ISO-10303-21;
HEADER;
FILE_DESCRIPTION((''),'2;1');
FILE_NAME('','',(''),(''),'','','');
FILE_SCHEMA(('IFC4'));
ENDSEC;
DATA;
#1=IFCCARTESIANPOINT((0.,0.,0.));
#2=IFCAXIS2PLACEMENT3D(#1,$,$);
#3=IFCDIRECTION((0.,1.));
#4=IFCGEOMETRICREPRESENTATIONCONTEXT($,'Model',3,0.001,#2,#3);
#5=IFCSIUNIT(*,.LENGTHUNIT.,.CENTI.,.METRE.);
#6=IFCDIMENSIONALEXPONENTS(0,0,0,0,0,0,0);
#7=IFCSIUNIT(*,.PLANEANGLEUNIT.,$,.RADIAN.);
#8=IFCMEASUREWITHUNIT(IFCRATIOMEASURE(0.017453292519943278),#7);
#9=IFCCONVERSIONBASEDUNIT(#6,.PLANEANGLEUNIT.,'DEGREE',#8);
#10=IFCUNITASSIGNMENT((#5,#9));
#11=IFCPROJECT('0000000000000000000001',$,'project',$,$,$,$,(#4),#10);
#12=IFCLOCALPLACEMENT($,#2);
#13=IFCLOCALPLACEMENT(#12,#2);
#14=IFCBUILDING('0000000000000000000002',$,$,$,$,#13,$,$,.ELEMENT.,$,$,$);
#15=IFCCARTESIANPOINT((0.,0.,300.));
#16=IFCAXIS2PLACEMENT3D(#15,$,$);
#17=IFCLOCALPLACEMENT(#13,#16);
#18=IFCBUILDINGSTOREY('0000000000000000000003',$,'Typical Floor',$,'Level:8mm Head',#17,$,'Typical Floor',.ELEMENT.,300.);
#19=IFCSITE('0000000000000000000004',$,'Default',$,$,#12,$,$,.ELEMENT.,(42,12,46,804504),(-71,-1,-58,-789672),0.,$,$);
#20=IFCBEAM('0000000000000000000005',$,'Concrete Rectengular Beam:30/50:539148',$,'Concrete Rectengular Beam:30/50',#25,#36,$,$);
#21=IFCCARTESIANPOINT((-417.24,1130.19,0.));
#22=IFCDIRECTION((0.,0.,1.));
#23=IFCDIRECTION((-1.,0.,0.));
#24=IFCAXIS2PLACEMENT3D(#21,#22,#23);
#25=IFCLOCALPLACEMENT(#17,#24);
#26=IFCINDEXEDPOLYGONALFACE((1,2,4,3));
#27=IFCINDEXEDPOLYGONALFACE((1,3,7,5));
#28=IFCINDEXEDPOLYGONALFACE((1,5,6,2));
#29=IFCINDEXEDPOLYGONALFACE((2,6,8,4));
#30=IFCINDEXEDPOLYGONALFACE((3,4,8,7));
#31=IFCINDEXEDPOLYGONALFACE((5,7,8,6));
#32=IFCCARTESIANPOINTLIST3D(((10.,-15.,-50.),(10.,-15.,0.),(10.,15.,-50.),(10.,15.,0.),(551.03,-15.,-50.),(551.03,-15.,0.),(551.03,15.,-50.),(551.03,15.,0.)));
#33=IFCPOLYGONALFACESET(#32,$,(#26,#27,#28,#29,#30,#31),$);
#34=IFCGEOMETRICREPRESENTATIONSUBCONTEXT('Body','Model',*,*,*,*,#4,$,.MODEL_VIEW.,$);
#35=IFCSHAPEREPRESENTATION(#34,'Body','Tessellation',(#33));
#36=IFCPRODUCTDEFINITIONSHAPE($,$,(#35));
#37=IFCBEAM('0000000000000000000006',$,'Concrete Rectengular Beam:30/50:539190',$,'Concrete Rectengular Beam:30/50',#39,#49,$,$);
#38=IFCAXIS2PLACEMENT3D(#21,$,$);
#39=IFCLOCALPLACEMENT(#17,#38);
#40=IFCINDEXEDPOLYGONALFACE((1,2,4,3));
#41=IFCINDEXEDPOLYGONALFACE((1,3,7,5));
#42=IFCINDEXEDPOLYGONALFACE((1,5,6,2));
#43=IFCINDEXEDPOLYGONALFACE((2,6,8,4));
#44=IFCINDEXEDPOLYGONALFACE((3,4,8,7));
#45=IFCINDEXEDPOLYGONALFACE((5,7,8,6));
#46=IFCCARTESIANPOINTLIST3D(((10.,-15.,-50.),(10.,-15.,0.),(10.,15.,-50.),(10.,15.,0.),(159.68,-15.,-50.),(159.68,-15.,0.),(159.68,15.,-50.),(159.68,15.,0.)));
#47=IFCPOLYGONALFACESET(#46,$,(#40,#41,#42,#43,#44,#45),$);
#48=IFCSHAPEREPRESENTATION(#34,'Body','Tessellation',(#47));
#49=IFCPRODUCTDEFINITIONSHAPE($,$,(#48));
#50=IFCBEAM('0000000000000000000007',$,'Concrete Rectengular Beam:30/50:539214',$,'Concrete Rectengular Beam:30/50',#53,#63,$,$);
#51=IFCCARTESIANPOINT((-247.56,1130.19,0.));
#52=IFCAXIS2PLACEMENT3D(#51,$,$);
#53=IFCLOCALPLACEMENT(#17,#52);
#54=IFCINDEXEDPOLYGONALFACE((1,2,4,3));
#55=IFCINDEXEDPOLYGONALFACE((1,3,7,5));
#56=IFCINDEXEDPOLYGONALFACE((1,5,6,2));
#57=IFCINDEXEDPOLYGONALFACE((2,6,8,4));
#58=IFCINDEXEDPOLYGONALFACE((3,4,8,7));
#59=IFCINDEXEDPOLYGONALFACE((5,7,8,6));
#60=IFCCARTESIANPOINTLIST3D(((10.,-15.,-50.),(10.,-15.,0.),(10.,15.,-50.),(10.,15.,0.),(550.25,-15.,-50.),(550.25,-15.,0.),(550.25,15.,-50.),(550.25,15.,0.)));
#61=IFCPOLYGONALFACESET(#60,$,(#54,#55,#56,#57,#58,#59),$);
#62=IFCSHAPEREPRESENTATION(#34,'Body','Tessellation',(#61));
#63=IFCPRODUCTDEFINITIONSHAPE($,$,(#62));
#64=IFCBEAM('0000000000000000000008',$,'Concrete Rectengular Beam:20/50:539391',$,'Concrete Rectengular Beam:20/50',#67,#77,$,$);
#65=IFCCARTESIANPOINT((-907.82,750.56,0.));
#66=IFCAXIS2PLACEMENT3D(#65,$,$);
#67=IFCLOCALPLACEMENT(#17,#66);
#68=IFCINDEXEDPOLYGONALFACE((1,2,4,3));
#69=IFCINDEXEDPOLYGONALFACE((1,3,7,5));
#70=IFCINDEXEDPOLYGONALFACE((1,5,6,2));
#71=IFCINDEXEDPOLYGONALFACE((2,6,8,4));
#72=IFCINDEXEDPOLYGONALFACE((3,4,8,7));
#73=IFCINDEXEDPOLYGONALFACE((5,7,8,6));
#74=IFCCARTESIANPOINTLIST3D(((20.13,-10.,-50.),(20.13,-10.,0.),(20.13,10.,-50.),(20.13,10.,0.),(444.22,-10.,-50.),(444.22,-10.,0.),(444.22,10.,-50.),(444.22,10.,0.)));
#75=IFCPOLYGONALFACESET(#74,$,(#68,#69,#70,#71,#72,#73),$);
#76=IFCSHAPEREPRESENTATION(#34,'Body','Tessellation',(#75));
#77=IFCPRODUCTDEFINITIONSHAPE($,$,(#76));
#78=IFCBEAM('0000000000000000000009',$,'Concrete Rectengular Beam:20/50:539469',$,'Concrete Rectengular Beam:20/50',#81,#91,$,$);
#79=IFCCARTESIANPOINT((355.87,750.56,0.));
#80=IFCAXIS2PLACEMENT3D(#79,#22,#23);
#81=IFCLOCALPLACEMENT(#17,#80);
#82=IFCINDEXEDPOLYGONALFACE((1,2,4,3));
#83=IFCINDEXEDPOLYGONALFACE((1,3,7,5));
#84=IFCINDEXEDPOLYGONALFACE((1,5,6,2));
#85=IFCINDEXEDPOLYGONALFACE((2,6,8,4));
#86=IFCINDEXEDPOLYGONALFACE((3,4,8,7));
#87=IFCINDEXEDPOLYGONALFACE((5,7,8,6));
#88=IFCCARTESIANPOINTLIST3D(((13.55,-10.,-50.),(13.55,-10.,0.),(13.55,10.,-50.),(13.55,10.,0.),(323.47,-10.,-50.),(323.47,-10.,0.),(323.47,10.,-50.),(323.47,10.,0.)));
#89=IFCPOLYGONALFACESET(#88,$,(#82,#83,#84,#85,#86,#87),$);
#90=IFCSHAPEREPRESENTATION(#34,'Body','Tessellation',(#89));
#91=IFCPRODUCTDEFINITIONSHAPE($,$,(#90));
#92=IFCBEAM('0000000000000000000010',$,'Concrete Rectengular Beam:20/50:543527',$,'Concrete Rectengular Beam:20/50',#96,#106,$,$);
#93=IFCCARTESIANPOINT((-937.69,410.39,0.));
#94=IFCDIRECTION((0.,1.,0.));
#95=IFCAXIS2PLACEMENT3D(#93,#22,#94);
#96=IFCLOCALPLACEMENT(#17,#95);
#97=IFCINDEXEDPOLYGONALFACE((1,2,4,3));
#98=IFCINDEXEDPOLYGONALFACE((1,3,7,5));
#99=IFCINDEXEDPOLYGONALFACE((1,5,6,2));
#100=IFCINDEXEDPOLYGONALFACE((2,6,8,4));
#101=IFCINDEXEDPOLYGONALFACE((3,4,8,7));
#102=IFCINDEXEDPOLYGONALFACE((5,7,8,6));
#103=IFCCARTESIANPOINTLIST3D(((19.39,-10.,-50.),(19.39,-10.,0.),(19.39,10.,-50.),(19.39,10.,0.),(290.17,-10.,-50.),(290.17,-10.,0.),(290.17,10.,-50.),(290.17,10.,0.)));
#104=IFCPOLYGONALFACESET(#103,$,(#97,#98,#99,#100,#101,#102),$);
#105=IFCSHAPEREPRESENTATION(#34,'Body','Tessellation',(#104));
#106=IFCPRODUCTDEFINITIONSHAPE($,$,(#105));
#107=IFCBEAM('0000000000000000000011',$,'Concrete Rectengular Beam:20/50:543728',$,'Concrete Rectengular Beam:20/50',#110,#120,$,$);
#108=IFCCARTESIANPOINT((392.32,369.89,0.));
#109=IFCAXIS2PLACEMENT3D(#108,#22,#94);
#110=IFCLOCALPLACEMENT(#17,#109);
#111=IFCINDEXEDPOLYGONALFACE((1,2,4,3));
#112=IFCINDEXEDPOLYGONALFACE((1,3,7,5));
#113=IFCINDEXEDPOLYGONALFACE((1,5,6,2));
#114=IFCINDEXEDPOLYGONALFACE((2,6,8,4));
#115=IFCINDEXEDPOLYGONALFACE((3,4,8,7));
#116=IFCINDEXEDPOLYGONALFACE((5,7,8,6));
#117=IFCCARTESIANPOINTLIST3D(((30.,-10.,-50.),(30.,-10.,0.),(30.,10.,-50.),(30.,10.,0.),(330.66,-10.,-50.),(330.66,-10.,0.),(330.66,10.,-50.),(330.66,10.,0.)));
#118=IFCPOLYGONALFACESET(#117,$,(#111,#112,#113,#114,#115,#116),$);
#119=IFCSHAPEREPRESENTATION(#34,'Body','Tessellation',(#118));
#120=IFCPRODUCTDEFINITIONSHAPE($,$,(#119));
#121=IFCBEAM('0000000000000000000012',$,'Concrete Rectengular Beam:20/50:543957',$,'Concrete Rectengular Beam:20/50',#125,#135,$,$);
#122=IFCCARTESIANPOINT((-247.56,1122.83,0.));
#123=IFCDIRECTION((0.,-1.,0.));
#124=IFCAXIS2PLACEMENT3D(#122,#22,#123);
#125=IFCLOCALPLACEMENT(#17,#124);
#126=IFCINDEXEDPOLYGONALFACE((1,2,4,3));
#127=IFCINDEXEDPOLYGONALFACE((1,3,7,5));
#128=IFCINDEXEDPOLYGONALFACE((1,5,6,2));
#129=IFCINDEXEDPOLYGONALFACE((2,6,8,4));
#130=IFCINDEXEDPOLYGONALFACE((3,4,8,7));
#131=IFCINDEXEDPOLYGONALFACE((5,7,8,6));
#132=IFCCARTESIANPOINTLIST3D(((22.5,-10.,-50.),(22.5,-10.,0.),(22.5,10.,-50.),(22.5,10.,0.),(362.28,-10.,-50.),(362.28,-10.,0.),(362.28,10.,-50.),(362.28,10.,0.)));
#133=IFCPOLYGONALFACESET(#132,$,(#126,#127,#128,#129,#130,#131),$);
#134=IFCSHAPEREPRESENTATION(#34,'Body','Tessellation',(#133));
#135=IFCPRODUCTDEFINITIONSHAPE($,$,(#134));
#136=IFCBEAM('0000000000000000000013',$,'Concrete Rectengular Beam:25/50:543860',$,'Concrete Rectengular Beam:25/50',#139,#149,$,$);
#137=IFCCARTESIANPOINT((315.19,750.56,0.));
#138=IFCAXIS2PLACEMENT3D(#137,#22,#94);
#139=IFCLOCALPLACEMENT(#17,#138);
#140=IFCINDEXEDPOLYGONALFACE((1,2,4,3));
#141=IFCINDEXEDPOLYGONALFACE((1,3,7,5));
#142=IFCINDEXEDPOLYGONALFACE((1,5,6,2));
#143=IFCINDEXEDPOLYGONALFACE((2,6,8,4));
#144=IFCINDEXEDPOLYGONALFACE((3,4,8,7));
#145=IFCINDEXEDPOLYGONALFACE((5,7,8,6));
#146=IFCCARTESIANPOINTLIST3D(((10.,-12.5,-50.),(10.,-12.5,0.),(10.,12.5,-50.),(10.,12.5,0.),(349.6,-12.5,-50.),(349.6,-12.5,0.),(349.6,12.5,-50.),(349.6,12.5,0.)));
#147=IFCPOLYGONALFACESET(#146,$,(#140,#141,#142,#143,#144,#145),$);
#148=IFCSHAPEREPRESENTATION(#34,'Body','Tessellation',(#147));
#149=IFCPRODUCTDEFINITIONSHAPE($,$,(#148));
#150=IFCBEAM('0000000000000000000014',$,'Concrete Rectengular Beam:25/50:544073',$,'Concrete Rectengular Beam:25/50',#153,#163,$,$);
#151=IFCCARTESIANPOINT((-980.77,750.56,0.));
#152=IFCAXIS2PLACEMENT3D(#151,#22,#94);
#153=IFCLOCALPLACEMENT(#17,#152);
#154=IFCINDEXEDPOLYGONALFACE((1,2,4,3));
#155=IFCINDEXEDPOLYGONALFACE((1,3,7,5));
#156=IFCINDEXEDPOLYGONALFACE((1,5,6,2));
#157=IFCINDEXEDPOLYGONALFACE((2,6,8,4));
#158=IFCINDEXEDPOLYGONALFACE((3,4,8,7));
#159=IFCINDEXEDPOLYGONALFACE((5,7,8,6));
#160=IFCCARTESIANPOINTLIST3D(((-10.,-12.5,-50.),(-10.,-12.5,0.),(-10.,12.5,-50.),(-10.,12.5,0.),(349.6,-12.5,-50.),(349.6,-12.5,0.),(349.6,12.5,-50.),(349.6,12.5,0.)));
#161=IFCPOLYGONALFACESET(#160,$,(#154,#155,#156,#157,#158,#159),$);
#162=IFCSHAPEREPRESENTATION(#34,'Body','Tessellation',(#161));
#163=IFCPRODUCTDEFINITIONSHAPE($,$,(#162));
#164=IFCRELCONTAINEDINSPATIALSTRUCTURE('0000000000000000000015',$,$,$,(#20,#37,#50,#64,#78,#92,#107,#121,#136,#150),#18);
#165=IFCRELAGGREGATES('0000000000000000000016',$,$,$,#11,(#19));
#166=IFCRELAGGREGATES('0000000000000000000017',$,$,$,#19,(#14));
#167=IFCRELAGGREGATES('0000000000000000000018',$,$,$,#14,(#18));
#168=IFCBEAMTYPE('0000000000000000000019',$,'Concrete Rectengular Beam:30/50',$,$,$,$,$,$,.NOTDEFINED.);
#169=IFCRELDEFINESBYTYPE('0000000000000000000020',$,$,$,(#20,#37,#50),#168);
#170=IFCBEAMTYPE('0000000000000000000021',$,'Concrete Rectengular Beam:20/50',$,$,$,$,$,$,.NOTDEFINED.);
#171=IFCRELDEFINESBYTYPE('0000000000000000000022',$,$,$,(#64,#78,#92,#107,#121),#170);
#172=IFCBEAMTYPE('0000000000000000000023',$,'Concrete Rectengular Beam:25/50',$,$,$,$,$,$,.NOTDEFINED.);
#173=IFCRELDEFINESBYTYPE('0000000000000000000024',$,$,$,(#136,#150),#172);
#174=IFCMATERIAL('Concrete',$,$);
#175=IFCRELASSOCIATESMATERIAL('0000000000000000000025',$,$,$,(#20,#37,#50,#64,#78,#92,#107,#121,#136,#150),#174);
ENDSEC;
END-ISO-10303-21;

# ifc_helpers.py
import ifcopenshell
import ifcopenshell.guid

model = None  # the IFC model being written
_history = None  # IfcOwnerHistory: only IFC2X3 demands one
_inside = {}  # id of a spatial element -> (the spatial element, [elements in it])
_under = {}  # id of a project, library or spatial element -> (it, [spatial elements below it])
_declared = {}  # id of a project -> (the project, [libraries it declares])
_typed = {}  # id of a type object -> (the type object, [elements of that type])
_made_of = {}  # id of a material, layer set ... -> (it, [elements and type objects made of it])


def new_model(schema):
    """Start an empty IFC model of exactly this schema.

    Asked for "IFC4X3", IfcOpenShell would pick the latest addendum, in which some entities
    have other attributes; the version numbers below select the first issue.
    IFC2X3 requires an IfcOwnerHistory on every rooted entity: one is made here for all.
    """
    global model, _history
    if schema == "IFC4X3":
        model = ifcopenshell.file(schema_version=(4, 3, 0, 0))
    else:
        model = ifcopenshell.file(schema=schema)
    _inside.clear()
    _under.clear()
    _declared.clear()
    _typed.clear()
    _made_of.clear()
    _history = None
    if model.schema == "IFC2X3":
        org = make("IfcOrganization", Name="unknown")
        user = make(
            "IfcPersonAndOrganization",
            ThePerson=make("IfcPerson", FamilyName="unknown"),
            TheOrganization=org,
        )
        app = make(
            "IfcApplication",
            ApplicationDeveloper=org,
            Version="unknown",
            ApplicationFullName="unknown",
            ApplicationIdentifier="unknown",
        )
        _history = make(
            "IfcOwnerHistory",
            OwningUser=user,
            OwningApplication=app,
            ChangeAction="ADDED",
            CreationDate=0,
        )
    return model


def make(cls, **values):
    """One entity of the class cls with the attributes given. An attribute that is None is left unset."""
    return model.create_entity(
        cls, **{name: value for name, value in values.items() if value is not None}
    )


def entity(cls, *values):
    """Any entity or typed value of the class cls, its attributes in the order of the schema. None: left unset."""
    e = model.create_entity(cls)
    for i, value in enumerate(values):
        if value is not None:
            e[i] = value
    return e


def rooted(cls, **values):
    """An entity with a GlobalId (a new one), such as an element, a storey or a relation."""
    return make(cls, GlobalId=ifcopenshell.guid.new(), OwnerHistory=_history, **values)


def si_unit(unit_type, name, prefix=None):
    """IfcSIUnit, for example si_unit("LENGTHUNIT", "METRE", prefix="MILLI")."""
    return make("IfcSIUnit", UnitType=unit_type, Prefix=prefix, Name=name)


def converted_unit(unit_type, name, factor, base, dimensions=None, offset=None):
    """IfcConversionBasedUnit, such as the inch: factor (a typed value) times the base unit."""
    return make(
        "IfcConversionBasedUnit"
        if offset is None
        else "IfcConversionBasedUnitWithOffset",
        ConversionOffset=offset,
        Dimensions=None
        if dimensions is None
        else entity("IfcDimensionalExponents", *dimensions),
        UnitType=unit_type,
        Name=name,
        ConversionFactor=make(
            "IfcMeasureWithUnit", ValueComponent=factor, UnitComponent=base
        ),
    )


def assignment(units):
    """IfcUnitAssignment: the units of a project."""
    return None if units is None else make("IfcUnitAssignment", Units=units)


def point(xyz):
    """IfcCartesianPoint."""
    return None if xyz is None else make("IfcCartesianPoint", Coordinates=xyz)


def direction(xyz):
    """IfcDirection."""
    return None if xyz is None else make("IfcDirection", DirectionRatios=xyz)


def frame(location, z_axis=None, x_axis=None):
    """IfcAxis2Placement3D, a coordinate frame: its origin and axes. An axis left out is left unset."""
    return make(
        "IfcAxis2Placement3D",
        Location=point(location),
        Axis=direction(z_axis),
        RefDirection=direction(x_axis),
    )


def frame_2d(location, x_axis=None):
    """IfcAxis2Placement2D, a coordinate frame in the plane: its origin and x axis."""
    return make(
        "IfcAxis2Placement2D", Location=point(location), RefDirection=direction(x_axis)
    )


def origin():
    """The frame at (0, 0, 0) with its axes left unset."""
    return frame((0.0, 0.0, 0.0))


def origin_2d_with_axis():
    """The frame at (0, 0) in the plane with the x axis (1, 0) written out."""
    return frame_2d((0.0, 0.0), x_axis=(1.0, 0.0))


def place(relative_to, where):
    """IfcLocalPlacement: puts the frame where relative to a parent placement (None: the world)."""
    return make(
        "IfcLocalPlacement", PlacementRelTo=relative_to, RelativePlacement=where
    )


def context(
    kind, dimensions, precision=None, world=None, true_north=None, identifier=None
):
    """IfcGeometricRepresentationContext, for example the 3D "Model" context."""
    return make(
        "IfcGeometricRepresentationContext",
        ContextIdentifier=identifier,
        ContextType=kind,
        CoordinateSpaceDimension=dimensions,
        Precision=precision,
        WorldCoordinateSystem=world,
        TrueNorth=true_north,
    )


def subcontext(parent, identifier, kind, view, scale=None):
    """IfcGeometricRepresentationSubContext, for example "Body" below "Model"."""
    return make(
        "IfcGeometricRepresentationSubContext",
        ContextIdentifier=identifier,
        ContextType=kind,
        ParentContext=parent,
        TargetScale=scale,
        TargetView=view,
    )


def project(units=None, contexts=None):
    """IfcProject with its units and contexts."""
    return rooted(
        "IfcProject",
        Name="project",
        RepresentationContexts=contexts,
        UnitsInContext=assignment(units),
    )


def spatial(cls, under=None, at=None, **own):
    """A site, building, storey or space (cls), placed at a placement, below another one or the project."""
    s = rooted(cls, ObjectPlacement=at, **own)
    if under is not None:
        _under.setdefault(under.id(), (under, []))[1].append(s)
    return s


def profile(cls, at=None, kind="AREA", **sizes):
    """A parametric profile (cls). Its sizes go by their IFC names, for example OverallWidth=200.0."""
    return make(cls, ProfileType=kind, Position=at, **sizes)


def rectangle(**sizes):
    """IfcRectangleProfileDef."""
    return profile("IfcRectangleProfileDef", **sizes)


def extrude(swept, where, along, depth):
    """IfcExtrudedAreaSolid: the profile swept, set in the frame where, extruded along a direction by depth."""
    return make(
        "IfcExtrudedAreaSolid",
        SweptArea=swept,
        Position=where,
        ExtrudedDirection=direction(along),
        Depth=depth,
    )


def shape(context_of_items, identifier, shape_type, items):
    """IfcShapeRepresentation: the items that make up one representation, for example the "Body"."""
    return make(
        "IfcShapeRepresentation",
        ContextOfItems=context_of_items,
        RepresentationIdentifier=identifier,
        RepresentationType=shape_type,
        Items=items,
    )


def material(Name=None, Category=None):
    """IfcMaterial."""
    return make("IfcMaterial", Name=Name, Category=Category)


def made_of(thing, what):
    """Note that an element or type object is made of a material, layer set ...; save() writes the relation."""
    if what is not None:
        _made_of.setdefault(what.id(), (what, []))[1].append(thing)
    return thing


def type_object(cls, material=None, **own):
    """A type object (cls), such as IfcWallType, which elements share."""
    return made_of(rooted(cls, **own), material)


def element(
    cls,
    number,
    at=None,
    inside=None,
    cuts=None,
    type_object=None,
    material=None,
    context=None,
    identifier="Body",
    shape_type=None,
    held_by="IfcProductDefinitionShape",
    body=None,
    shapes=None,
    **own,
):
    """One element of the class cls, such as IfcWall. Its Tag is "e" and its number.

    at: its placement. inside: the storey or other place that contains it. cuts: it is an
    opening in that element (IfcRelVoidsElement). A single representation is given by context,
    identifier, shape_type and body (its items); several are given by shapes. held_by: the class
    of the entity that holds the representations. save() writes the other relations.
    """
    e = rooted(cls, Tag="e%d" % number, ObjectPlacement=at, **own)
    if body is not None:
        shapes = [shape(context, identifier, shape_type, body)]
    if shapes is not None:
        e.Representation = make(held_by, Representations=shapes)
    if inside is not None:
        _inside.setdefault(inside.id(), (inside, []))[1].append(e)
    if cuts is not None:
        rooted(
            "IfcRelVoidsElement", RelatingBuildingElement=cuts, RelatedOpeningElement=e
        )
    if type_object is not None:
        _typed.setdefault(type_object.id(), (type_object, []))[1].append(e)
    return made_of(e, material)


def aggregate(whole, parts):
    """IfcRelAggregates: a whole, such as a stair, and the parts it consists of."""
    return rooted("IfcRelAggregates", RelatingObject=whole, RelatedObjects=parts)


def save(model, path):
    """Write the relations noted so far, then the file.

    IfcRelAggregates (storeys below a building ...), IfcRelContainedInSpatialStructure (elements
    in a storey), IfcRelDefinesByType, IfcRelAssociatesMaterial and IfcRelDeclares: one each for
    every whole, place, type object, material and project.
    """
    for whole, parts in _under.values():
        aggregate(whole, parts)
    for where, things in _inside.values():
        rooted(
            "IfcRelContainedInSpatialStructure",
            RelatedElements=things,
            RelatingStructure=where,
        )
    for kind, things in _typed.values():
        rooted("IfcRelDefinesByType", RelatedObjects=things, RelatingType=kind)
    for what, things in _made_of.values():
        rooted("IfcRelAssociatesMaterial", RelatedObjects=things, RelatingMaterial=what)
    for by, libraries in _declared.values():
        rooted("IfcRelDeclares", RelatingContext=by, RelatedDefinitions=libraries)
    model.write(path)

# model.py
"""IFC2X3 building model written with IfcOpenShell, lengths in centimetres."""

from ifc_helpers import new_model, entity, si_unit, converted_unit, direction, frame, frame_2d, origin, origin_2d_with_axis, place, context, subcontext, project, spatial, rectangle, extrude, material, type_object, element, save


model = new_model("IFC2X3")

# Units and contexts
model_context = context("Model", 3, precision=0.001, world=origin(), true_north=direction((0.0, 1.0)))
body_context = subcontext(model_context, "Body", "Model", "MODEL_VIEW")
ifc_project = project(units=[si_unit("LENGTHUNIT", "METRE", prefix="CENTI"), converted_unit("PLANEANGLEUNIT", "DEGREE", entity("IfcRatioMeasure", 0.017453292519943278), si_unit("PLANEANGLEUNIT", "RADIAN"), dimensions=[0, 0, 0, 0, 0, 0, 0])], contexts=[model_context])

# Site, building, storey
site_placement = place(None, origin())
site = spatial("IfcSite", under=ifc_project, at=site_placement, Name="Default", CompositionType="ELEMENT", RefLatitude=(42, 12, 46, 804504), RefLongitude=(-71, -1, -58, -789672), RefElevation=0.0)
building_placement = place(site_placement, origin())
building = spatial("IfcBuilding", under=site, at=building_placement, CompositionType="ELEMENT")
storey_placement = place(building_placement, frame((0.0, 0.0, 300.0)))
storey = spatial("IfcBuildingStorey", under=building, at=storey_placement, Name="Typical Floor", ObjectType="Level:8mm Head", LongName="Typical Floor", CompositionType="ELEMENT", Elevation=300.0)

# Beams
ifc_material = material(Name="Concrete")
beam_type_1 = type_object("IfcBeamType", Name="Concrete Rectengular Beam:30/50", PredefinedType="NOTDEFINED")
beam_1_placement = place(storey_placement, frame((-417.24, 1130.19, 0.0), z_axis=(0.0, 0.0, 1.0), x_axis=(-1.0, 0.0, 0.0)))
element("IfcBeam", 1, at=beam_1_placement, inside=storey, type_object=beam_type_1, material=ifc_material, Name="Concrete Rectengular Beam:30/50:539148", ObjectType="Concrete Rectengular Beam:30/50", context=body_context, shape_type="SweptSolid", body=[
    extrude(rectangle(XDim=50.0, YDim=30.0, at=frame_2d((0.0, 0.0), x_axis=(1.0, 0.0))), frame((10.0, 0.0, -25.0), z_axis=(1.0, 0.0, 0.0), x_axis=(0.0, 0.0, -1.0)), (0.0, 0.0, 1.0), 541.03),
])
beam_2_placement = place(storey_placement, frame((-417.24, 1130.19, 0.0)))
element("IfcBeam", 2, at=beam_2_placement, inside=storey, type_object=beam_type_1, material=ifc_material, Name="Concrete Rectengular Beam:30/50:539190", ObjectType="Concrete Rectengular Beam:30/50", context=body_context, shape_type="SweptSolid", body=[
    extrude(rectangle(XDim=50.0, YDim=30.0, at=frame_2d((0.0, 0.0), x_axis=(1.0, 0.0))), frame((10.0, 0.0, -25.0), z_axis=(1.0, 0.0, 0.0), x_axis=(0.0, 0.0, -1.0)), (0.0, 0.0, 1.0), 149.68),
])
beam_3_placement = place(storey_placement, frame((-247.56, 1130.19, 0.0)))
element("IfcBeam", 3, at=beam_3_placement, inside=storey, type_object=beam_type_1, material=ifc_material, Name="Concrete Rectengular Beam:30/50:539214", ObjectType="Concrete Rectengular Beam:30/50", context=body_context, shape_type="SweptSolid", body=[
    extrude(rectangle(XDim=50.0, YDim=30.0, at=frame_2d((0.0, 0.0), x_axis=(1.0, 0.0))), frame((10.0, 0.0, -25.0), z_axis=(1.0, 0.0, 0.0), x_axis=(0.0, 0.0, -1.0)), (0.0, 0.0, 1.0), 540.25),
])
beam_type_2 = type_object("IfcBeamType", Name="Concrete Rectengular Beam:20/50", PredefinedType="NOTDEFINED")
beam_4_placement = place(storey_placement, frame((-907.82, 750.56, 0.0)))
element("IfcBeam", 4, at=beam_4_placement, inside=storey, type_object=beam_type_2, material=ifc_material, Name="Concrete Rectengular Beam:20/50:539391", ObjectType="Concrete Rectengular Beam:20/50", context=body_context, shape_type="SweptSolid", body=[
    extrude(rectangle(XDim=50.0, YDim=20.0, at=frame_2d((0.0, 0.0), x_axis=(1.0, 0.0))), frame((20.13, 0.0, -25.0), z_axis=(1.0, 0.0, 0.0), x_axis=(0.0, 0.0, -1.0)), (0.0, 0.0, 1.0), 424.09),
])
beam_5_placement = place(storey_placement, frame((355.87, 750.56, 0.0), z_axis=(0.0, 0.0, 1.0), x_axis=(-1.0, 0.0, 0.0)))
element("IfcBeam", 5, at=beam_5_placement, inside=storey, type_object=beam_type_2, material=ifc_material, Name="Concrete Rectengular Beam:20/50:539469", ObjectType="Concrete Rectengular Beam:20/50", context=body_context, shape_type="SweptSolid", body=[
    extrude(rectangle(XDim=50.0, YDim=20.0, at=frame_2d((0.0, 0.0), x_axis=(1.0, 0.0))), frame((13.55, 0.0, -25.0), z_axis=(1.0, 0.0, 0.0), x_axis=(0.0, 0.0, -1.0)), (0.0, 0.0, 1.0), 309.92),
])
beam_6_placement = place(storey_placement, frame((-937.69, 410.39, 0.0), z_axis=(0.0, 0.0, 1.0), x_axis=(0.0, 1.0, 0.0)))
element("IfcBeam", 6, at=beam_6_placement, inside=storey, type_object=beam_type_2, material=ifc_material, Name="Concrete Rectengular Beam:20/50:543527", ObjectType="Concrete Rectengular Beam:20/50", context=body_context, shape_type="SweptSolid", body=[
    extrude(rectangle(XDim=50.0, YDim=20.0, at=frame_2d((0.0, 0.0), x_axis=(1.0, 0.0))), frame((19.39, 0.0, -25.0), z_axis=(1.0, 0.0, 0.0), x_axis=(0.0, 0.0, -1.0)), (0.0, 0.0, 1.0), 270.78),
])
beam_7_placement = place(storey_placement, frame((392.32, 369.89, 0.0), z_axis=(0.0, 0.0, 1.0), x_axis=(0.0, 1.0, 0.0)))
element("IfcBeam", 7, at=beam_7_placement, inside=storey, type_object=beam_type_2, material=ifc_material, Name="Concrete Rectengular Beam:20/50:543728", ObjectType="Concrete Rectengular Beam:20/50", context=body_context, shape_type="SweptSolid", body=[
    extrude(rectangle(XDim=50.0, YDim=20.0, at=frame_2d((0.0, 0.0), x_axis=(1.0, 0.0))), frame((30.0, 0.0, -25.0), z_axis=(1.0, 0.0, 0.0), x_axis=(0.0, 0.0, -1.0)), (0.0, 0.0, 1.0), 300.66),
])
beam_8_placement = place(storey_placement, frame((-247.56, 1122.83, 0.0), z_axis=(0.0, 0.0, 1.0), x_axis=(0.0, -1.0, 0.0)))
element("IfcBeam", 8, at=beam_8_placement, inside=storey, type_object=beam_type_2, material=ifc_material, Name="Concrete Rectengular Beam:20/50:543957", ObjectType="Concrete Rectengular Beam:20/50", context=body_context, shape_type="SweptSolid", body=[
    extrude(rectangle(XDim=50.0, YDim=20.0, at=frame_2d((0.0, 0.0), x_axis=(1.0, 0.0))), frame((22.5, 0.0, -25.0), z_axis=(1.0, 0.0, 0.0), x_axis=(0.0, 0.0, -1.0)), (0.0, 0.0, 1.0), 339.78),
])
beam_type_3 = type_object("IfcBeamType", Name="Concrete Rectengular Beam:25/50", PredefinedType="NOTDEFINED")
beam_9_placement = place(storey_placement, frame((315.19, 750.56, 0.0), z_axis=(0.0, 0.0, 1.0), x_axis=(0.0, 1.0, 0.0)))
element("IfcBeam", 9, at=beam_9_placement, inside=storey, type_object=beam_type_3, material=ifc_material, Name="Concrete Rectengular Beam:25/50:543860", ObjectType="Concrete Rectengular Beam:25/50", context=body_context, shape_type="SweptSolid", body=[
    extrude(rectangle(XDim=50.0, YDim=25.0, at=origin_2d_with_axis()), frame((10.0, 0.0, -25.0), z_axis=(1.0, 0.0, 0.0), x_axis=(0.0, 0.0, -1.0)), (0.0, 0.0, 1.0), 339.6),
])
beam_10_placement = place(storey_placement, frame((-980.77, 750.56, 0.0), z_axis=(0.0, 0.0, 1.0), x_axis=(0.0, 1.0, 0.0)))
element("IfcBeam", 10, at=beam_10_placement, inside=storey, type_object=beam_type_3, material=ifc_material, Name="Concrete Rectengular Beam:25/50:544073", ObjectType="Concrete Rectengular Beam:25/50", context=body_context, shape_type="SweptSolid", body=[
    extrude(rectangle(XDim=50.0, YDim=25.0, at=frame_2d((0.0, 0.0), x_axis=(1.0, 0.0))), frame((-10.0, 0.0, -25.0), z_axis=(1.0, 0.0, 0.0), x_axis=(0.0, 0.0, -1.0)), (0.0, 0.0, 1.0), 359.6),
])

save(model, "model.ifc")
